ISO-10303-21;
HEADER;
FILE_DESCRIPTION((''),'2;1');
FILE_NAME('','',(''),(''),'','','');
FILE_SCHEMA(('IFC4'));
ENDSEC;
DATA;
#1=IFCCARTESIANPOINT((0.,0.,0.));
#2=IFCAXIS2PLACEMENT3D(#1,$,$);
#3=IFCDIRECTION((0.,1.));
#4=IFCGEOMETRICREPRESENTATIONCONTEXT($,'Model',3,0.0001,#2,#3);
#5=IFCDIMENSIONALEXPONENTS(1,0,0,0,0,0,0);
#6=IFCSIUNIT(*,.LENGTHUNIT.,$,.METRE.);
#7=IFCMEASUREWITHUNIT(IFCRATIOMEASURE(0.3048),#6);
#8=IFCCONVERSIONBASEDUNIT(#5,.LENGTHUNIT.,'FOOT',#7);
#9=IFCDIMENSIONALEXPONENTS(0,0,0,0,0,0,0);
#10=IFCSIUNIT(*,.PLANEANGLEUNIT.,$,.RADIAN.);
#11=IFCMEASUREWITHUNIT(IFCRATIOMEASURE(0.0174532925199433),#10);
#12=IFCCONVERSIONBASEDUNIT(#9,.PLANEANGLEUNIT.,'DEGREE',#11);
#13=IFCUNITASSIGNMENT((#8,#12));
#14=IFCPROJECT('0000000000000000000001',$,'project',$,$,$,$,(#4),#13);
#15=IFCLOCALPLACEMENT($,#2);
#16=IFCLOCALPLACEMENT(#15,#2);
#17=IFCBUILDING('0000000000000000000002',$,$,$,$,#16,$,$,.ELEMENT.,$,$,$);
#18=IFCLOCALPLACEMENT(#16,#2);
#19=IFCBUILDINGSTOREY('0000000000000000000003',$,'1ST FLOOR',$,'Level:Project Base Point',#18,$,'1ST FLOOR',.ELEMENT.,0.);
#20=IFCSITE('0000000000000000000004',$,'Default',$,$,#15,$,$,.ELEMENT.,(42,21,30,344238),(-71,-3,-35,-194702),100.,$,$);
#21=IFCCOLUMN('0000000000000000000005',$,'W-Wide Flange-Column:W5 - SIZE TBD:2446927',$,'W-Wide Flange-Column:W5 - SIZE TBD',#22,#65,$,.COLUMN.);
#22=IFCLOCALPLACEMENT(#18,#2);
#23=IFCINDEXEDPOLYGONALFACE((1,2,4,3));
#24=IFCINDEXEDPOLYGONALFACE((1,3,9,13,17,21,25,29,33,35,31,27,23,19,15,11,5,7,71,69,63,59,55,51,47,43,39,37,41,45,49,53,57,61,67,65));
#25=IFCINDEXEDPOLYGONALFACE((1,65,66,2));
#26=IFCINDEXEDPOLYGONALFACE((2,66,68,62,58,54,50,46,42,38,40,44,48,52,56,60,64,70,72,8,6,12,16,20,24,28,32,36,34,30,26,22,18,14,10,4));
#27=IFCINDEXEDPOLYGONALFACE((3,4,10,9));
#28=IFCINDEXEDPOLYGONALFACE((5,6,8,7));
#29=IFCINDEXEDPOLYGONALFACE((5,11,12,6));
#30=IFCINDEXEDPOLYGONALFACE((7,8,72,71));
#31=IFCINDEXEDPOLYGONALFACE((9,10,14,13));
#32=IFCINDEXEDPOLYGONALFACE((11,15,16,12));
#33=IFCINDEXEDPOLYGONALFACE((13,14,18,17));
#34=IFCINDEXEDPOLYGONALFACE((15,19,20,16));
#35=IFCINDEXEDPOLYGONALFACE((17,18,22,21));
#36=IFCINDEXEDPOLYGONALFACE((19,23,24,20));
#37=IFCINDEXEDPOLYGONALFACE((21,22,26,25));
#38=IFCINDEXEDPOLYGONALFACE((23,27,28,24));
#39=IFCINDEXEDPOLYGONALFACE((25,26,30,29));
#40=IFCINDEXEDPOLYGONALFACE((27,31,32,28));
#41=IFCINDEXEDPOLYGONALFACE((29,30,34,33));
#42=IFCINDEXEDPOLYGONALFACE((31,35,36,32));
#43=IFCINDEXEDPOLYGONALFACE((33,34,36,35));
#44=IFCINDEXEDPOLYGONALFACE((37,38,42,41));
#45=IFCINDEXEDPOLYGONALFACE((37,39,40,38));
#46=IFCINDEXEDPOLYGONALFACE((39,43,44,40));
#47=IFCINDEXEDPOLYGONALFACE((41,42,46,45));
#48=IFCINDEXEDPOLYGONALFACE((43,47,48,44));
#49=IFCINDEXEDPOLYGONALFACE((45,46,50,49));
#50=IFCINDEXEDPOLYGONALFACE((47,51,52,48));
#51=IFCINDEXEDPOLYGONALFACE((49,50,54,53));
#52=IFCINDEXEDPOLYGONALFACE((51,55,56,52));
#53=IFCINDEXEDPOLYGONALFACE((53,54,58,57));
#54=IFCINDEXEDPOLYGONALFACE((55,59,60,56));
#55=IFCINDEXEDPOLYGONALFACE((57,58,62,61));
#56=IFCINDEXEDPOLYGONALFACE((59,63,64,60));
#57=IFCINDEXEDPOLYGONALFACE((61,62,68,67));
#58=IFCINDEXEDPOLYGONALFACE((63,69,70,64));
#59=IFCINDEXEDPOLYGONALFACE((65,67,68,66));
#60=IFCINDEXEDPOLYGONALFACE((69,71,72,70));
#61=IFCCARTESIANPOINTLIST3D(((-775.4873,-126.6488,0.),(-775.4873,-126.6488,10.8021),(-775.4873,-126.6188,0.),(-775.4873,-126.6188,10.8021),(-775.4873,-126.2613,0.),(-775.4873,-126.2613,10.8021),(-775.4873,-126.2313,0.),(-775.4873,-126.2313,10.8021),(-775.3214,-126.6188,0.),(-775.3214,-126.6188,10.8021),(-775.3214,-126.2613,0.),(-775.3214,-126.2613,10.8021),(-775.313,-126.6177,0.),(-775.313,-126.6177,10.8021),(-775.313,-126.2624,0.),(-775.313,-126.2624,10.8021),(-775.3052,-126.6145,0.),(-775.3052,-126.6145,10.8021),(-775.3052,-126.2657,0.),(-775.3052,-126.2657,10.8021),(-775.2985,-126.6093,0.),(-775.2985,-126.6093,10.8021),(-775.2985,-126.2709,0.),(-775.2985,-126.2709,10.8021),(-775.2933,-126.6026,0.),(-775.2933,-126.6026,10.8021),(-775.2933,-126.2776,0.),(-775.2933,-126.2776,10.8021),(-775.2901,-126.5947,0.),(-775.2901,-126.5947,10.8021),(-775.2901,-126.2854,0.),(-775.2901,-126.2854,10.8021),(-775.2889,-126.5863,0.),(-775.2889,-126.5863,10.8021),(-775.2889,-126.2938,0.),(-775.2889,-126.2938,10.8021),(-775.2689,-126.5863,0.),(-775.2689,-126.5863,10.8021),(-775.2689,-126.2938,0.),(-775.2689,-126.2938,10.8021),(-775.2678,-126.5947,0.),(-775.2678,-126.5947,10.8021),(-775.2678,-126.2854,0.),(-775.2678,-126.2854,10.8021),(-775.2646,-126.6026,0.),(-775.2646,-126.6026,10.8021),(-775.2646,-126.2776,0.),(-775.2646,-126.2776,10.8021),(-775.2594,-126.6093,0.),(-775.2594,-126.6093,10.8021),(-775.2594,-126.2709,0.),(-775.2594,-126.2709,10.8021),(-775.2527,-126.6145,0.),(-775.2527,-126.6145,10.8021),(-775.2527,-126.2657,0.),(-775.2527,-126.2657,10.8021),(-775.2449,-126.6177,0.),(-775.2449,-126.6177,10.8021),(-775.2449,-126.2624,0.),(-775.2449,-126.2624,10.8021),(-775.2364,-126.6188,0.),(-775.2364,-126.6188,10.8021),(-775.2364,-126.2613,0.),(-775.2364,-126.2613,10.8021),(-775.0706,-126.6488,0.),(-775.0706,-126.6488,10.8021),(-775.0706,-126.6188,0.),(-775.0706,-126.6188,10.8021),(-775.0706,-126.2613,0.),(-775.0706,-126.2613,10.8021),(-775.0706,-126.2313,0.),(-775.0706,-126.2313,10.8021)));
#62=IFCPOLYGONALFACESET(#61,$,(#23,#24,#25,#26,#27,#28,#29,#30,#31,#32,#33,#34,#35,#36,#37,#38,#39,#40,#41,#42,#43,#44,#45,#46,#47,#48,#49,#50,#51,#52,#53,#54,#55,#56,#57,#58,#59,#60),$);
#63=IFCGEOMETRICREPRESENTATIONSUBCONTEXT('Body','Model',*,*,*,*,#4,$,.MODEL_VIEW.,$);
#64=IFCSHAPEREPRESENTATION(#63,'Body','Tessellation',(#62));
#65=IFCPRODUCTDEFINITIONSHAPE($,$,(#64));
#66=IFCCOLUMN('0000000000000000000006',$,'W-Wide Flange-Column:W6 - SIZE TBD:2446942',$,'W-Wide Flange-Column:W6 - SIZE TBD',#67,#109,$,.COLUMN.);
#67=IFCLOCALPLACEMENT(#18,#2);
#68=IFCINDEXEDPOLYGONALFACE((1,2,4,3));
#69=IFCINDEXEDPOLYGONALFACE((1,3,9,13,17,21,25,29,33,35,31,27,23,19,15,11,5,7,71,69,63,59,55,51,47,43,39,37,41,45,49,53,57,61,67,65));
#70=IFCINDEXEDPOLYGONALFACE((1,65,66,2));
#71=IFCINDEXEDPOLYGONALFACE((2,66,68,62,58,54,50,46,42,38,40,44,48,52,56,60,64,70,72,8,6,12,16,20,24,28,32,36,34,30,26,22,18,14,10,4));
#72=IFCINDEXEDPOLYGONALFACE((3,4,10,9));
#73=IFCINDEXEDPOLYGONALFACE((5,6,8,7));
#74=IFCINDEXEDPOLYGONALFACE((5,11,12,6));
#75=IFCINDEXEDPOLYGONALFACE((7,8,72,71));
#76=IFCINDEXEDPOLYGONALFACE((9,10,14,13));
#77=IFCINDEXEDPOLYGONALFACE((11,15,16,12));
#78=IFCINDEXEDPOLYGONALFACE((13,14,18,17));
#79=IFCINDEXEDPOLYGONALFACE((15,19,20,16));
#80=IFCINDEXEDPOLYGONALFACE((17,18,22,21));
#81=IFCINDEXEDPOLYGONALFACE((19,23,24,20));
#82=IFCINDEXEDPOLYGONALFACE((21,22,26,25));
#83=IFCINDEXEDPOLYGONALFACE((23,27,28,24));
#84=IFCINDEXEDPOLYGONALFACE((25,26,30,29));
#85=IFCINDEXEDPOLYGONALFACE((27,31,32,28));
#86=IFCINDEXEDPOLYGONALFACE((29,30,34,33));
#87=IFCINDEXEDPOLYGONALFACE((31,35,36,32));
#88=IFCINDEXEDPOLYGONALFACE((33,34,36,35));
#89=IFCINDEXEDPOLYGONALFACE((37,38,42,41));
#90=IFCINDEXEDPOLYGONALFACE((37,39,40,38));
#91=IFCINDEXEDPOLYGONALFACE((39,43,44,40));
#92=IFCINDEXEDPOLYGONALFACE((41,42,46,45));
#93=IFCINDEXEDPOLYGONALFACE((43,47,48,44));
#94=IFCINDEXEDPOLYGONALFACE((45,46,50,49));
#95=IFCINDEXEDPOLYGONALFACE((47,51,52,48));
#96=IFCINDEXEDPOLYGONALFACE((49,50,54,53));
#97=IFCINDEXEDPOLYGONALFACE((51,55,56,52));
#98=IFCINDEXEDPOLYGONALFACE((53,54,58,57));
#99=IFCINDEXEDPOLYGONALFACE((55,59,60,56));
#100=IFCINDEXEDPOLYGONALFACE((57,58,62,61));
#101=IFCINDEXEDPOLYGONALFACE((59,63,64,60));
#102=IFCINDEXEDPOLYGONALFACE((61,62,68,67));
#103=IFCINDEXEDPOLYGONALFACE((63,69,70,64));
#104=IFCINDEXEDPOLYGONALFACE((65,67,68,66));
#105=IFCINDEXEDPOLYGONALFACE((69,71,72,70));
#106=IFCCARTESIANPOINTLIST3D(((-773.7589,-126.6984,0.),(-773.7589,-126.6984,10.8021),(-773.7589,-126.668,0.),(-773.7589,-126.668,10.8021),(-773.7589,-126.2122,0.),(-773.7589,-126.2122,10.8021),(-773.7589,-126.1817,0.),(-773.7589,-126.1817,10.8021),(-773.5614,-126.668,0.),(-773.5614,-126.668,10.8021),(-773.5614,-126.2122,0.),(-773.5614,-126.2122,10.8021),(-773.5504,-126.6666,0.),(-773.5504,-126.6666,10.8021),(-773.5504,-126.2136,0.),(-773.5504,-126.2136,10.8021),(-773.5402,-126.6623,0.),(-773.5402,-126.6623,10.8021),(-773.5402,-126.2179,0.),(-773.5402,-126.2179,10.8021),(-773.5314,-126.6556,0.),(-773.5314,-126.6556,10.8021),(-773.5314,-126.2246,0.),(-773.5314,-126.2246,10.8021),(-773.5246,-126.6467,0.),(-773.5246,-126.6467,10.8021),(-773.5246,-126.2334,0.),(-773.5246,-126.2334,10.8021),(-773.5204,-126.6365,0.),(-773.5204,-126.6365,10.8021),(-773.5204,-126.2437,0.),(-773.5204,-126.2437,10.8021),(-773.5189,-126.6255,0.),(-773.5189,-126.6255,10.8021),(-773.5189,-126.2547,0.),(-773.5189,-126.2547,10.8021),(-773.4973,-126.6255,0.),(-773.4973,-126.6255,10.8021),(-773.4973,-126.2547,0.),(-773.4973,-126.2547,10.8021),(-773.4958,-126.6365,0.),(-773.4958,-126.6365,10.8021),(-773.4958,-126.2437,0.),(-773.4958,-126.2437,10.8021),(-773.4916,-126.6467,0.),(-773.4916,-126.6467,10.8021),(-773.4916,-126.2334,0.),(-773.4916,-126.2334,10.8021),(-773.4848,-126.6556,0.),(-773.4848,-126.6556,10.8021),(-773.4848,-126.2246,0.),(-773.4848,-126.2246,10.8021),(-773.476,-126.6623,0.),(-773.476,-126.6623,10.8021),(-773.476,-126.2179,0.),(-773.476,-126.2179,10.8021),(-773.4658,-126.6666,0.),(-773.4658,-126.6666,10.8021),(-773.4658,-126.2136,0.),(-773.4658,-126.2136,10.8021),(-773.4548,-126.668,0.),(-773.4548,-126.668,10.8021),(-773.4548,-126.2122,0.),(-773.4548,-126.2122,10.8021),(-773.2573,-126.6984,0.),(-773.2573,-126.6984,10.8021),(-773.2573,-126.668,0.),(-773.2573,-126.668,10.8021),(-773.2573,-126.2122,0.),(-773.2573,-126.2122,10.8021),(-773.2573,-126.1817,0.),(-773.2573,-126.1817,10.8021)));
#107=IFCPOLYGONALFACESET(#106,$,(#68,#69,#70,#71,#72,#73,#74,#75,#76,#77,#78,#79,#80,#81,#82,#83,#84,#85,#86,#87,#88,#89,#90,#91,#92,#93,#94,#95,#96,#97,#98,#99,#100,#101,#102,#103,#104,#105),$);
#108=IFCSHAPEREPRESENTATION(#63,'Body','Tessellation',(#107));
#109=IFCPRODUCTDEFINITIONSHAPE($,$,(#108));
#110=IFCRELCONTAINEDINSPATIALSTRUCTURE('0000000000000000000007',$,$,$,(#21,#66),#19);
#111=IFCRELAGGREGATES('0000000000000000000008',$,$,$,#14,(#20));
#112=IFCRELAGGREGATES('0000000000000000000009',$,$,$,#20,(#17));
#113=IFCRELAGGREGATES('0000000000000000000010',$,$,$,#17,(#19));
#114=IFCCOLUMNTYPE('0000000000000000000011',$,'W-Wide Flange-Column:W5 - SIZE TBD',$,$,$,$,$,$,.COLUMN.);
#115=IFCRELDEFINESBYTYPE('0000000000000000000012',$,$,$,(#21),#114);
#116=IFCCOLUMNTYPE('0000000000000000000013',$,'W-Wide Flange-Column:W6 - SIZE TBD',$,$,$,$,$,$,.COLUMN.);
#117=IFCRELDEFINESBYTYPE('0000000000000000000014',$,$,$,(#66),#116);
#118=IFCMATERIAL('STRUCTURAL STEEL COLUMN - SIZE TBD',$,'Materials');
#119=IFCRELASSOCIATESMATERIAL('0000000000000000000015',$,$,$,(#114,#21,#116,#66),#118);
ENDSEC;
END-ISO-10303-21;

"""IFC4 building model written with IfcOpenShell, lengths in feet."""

from ifc_helpers import new_model, entity, si_unit, converted_unit, direction, frame, frame_2d, origin, place, context, subcontext, project, spatial, polyline, circle_curve, parameter, trimmed, segment, composite_curve, outline, extrude, source, transform, mapped, material, material_profile, profile_set, profile_usage, type_object, type_shapes, element, save


model = new_model("IFC4")

# Units and contexts
model_context = context("Model", 3, precision=0.0001, world=origin(), true_north=direction((0.0, 1.0)))
body_context = subcontext(model_context, "Body", "Model", "MODEL_VIEW")
ifc_project = project(units=[converted_unit("LENGTHUNIT", "FOOT", entity("IfcRatioMeasure", 0.3048), si_unit("LENGTHUNIT", "METRE"), dimensions=[1, 0, 0, 0, 0, 0, 0]), converted_unit("PLANEANGLEUNIT", "DEGREE", entity("IfcRatioMeasure", 0.0174532925199433), si_unit("PLANEANGLEUNIT", "RADIAN"), dimensions=[0, 0, 0, 0, 0, 0, 0])], contexts=[model_context])

# Site, building, storey
site_placement = place(None, origin())
site = spatial("IfcSite", under=ifc_project, at=site_placement, Name="Default", CompositionType="ELEMENT", RefLatitude=(42, 21, 30, 344238), RefLongitude=(-71, -3, -35, -194702), RefElevation=100.0)
building_placement = place(site_placement, origin())
building = spatial("IfcBuilding", under=site, at=building_placement, CompositionType="ELEMENT")
storey_placement = place(building_placement, origin())
storey = spatial("IfcBuildingStorey", under=building, at=storey_placement, Name="1ST FLOOR", ObjectType="Level:Project Base Point", LongName="1ST FLOOR", CompositionType="ELEMENT", Elevation=0.0)

# Columns
ifc_material_1 = material(Name="STRUCTURAL STEEL COLUMN - SIZE TBD", Category="Materials")
ifc_material_profile_1 = material_profile(ifc_material_1, outline(composite_curve([segment(polyline([(0.1787, -0.2083), (0.2087, -0.2083)]), True, "CONTINUOUS"), segment(polyline([(0.2087, -0.2083), (0.2087, 0.2083)]), True, "CONTINUOUS"), segment(polyline([(0.2087, 0.2083), (0.1787, 0.2083)]), True, "CONTINUOUS"), segment(polyline([(0.1787, 0.2083), (0.1787, 0.0425)]), True, "CONTINUOUS"), segment(trimmed(circle_curve(frame_2d((0.1462, 0.0425), x_axis=(1.0, 0.0)), 0.0325), [parameter(270.0)], [parameter(0.0)], True, "PARAMETER"), False, "CONTINUOUS"), segment(polyline([(0.1462, 0.01), (-0.1462, 0.01)]), True, "CONTINUOUS"), segment(trimmed(circle_curve(frame_2d((-0.1462, 0.0425), x_axis=(0.0, -1.0)), 0.0325), [parameter(270.0)], [parameter(0.0)], True, "PARAMETER"), False, "CONTINUOUS"), segment(polyline([(-0.1787, 0.0425), (-0.1787, 0.2083)]), True, "CONTINUOUS"), segment(polyline([(-0.1787, 0.2083), (-0.2087, 0.2083)]), True, "CONTINUOUS"), segment(polyline([(-0.2087, 0.2083), (-0.2087, -0.2083)]), True, "CONTINUOUS"), segment(polyline([(-0.2087, -0.2083), (-0.1787, -0.2083)]), True, "CONTINUOUS"), segment(polyline([(-0.1787, -0.2083), (-0.1787, -0.0425)]), True, "CONTINUOUS"), segment(trimmed(circle_curve(frame_2d((-0.1462, -0.0425), x_axis=(-1.0, 0.0)), 0.0325), [parameter(270.0)], [parameter(0.0)], True, "PARAMETER"), False, "CONTINUOUS"), segment(polyline([(-0.1462, -0.01), (0.1462, -0.01)]), True, "CONTINUOUS"), segment(trimmed(circle_curve(frame_2d((0.1462, -0.0425), x_axis=(0.0, 1.0)), 0.0325), [parameter(270.0)], [parameter(0.0)], True, "PARAMETER"), False, "CONTINUOUS"), segment(polyline([(0.1787, -0.0425), (0.1787, -0.2083)]), True, "CONTINUOUS")], self_intersect=False)), Name="W5 - SIZE TBD")
ifc_profile_set_1 = profile_set([ifc_material_profile_1], Name="W5 - SIZE TBD")
ifc_profile_usage_1 = profile_usage(ifc_profile_set_1)
column_type_1 = type_object("IfcColumnType", Name="W-Wide Flange-Column:W5 - SIZE TBD", PredefinedType="COLUMN", material=ifc_profile_set_1)
shared_shape_1 = source(origin(), body_context, "Body", "SweptSolid", [
    extrude(outline(composite_curve([segment(polyline([(0.1787, -0.2083), (0.2087, -0.2083)]), True, "CONTINUOUS"), segment(polyline([(0.2087, -0.2083), (0.2087, 0.2083)]), True, "CONTINUOUS"), segment(polyline([(0.2087, 0.2083), (0.1787, 0.2083)]), True, "CONTINUOUS"), segment(polyline([(0.1787, 0.2083), (0.1787, 0.0425)]), True, "CONTINUOUS"), segment(trimmed(circle_curve(frame_2d((0.1462, 0.0425), x_axis=(1.0, 0.0)), 0.0325), [parameter(270.0)], [parameter(0.0)], True, "PARAMETER"), False, "CONTINUOUS"), segment(polyline([(0.1462, 0.01), (-0.1462, 0.01)]), True, "CONTINUOUS"), segment(trimmed(circle_curve(frame_2d((-0.1462, 0.0425), x_axis=(0.0, -1.0)), 0.0325), [parameter(270.0)], [parameter(0.0)], True, "PARAMETER"), False, "CONTINUOUS"), segment(polyline([(-0.1787, 0.0425), (-0.1787, 0.2083)]), True, "CONTINUOUS"), segment(polyline([(-0.1787, 0.2083), (-0.2087, 0.2083)]), True, "CONTINUOUS"), segment(polyline([(-0.2087, 0.2083), (-0.2087, -0.2083)]), True, "CONTINUOUS"), segment(polyline([(-0.2087, -0.2083), (-0.1787, -0.2083)]), True, "CONTINUOUS"), segment(polyline([(-0.1787, -0.2083), (-0.1787, -0.0425)]), True, "CONTINUOUS"), segment(trimmed(circle_curve(frame_2d((-0.1462, -0.0425), x_axis=(-1.0, 0.0)), 0.0325), [parameter(270.0)], [parameter(0.0)], True, "PARAMETER"), False, "CONTINUOUS"), segment(polyline([(-0.1462, -0.01), (0.1462, -0.01)]), True, "CONTINUOUS"), segment(trimmed(circle_curve(frame_2d((0.1462, -0.0425), x_axis=(0.0, 1.0)), 0.0325), [parameter(270.0)], [parameter(0.0)], True, "PARAMETER"), False, "CONTINUOUS"), segment(polyline([(0.1787, -0.0425), (0.1787, -0.2083)]), True, "CONTINUOUS")], self_intersect=False)), frame((0.0, 0.0, 0.0), z_axis=(0.0, 0.0, 1.0), x_axis=(0.0, -1.0, 0.0)), (0.0, 0.0, 1.0), 10.8021),
])
type_shapes(column_type_1, [shared_shape_1])
column_1_placement = place(storey_placement, frame((-775.2789, -126.4401, 0.0)))
element("IfcColumn", 1, at=column_1_placement, inside=storey, type_object=column_type_1, material=ifc_profile_usage_1, Name="W-Wide Flange-Column:W5 - SIZE TBD:2446927", ObjectType="W-Wide Flange-Column:W5 - SIZE TBD", PredefinedType="COLUMN", context=body_context, shape_type="MappedRepresentation", body=[
    mapped(shared_shape_1, transform((0.0, 0.0, 0.0), scale=1.0)),
])
ifc_material_profile_2 = material_profile(ifc_material_1, outline(composite_curve([segment(polyline([(0.2279, -0.2508), (0.2583, -0.2508)]), True, "CONTINUOUS"), segment(polyline([(0.2583, -0.2508), (0.2583, 0.2508)]), True, "CONTINUOUS"), segment(polyline([(0.2583, 0.2508), (0.2279, 0.2508)]), True, "CONTINUOUS"), segment(polyline([(0.2279, 0.2508), (0.2279, 0.0533)]), True, "CONTINUOUS"), segment(trimmed(circle_curve(frame_2d((0.1854, 0.0533), x_axis=(1.0, 0.0)), 0.0425), [parameter(270.0)], [parameter(0.0)], True, "PARAMETER"), False, "CONTINUOUS"), segment(polyline([(0.1854, 0.0108), (-0.1854, 0.0108)]), True, "CONTINUOUS"), segment(trimmed(circle_curve(frame_2d((-0.1854, 0.0533), x_axis=(0.0, -1.0)), 0.0425), [parameter(270.0)], [parameter(0.0)], True, "PARAMETER"), False, "CONTINUOUS"), segment(polyline([(-0.2279, 0.0533), (-0.2279, 0.2508)]), True, "CONTINUOUS"), segment(polyline([(-0.2279, 0.2508), (-0.2583, 0.2508)]), True, "CONTINUOUS"), segment(polyline([(-0.2583, 0.2508), (-0.2583, -0.2508)]), True, "CONTINUOUS"), segment(polyline([(-0.2583, -0.2508), (-0.2279, -0.2508)]), True, "CONTINUOUS"), segment(polyline([(-0.2279, -0.2508), (-0.2279, -0.0533)]), True, "CONTINUOUS"), segment(trimmed(circle_curve(frame_2d((-0.1854, -0.0533), x_axis=(-1.0, 0.0)), 0.0425), [parameter(270.0)], [parameter(0.0)], True, "PARAMETER"), False, "CONTINUOUS"), segment(polyline([(-0.1854, -0.0108), (0.1854, -0.0108)]), True, "CONTINUOUS"), segment(trimmed(circle_curve(frame_2d((0.1854, -0.0533), x_axis=(0.0, 1.0)), 0.0425), [parameter(270.0)], [parameter(0.0)], True, "PARAMETER"), False, "CONTINUOUS"), segment(polyline([(0.2279, -0.0533), (0.2279, -0.2508)]), True, "CONTINUOUS")], self_intersect=False)), Name="W6 - SIZE TBD")
ifc_profile_set_2 = profile_set([ifc_material_profile_2], Name="W6 - SIZE TBD")
ifc_profile_usage_2 = profile_usage(ifc_profile_set_2)
column_type_2 = type_object("IfcColumnType", Name="W-Wide Flange-Column:W6 - SIZE TBD", PredefinedType="COLUMN", material=ifc_profile_set_2)
shared_shape_2 = source(origin(), body_context, "Body", "SweptSolid", [
    extrude(outline(composite_curve([segment(polyline([(0.2279, -0.2508), (0.2583, -0.2508)]), True, "CONTINUOUS"), segment(polyline([(0.2583, -0.2508), (0.2583, 0.2508)]), True, "CONTINUOUS"), segment(polyline([(0.2583, 0.2508), (0.2279, 0.2508)]), True, "CONTINUOUS"), segment(polyline([(0.2279, 0.2508), (0.2279, 0.0533)]), True, "CONTINUOUS"), segment(trimmed(circle_curve(frame_2d((0.1854, 0.0533), x_axis=(1.0, 0.0)), 0.0425), [parameter(270.0)], [parameter(0.0)], True, "PARAMETER"), False, "CONTINUOUS"), segment(polyline([(0.1854, 0.0108), (-0.1854, 0.0108)]), True, "CONTINUOUS"), segment(trimmed(circle_curve(frame_2d((-0.1854, 0.0533), x_axis=(0.0, -1.0)), 0.0425), [parameter(270.0)], [parameter(0.0)], True, "PARAMETER"), False, "CONTINUOUS"), segment(polyline([(-0.2279, 0.0533), (-0.2279, 0.2508)]), True, "CONTINUOUS"), segment(polyline([(-0.2279, 0.2508), (-0.2583, 0.2508)]), True, "CONTINUOUS"), segment(polyline([(-0.2583, 0.2508), (-0.2583, -0.2508)]), True, "CONTINUOUS"), segment(polyline([(-0.2583, -0.2508), (-0.2279, -0.2508)]), True, "CONTINUOUS"), segment(polyline([(-0.2279, -0.2508), (-0.2279, -0.0533)]), True, "CONTINUOUS"), segment(trimmed(circle_curve(frame_2d((-0.1854, -0.0533), x_axis=(-1.0, 0.0)), 0.0425), [parameter(270.0)], [parameter(0.0)], True, "PARAMETER"), False, "CONTINUOUS"), segment(polyline([(-0.1854, -0.0108), (0.1854, -0.0108)]), True, "CONTINUOUS"), segment(trimmed(circle_curve(frame_2d((0.1854, -0.0533), x_axis=(0.0, 1.0)), 0.0425), [parameter(270.0)], [parameter(0.0)], True, "PARAMETER"), False, "CONTINUOUS"), segment(polyline([(0.2279, -0.0533), (0.2279, -0.2508)]), True, "CONTINUOUS")], self_intersect=False)), frame((0.0, 0.0, 0.0), z_axis=(0.0, 0.0, 1.0), x_axis=(0.0, -1.0, 0.0)), (0.0, 0.0, 1.0), 10.8021),
])
type_shapes(column_type_2, [shared_shape_2])
column_2_placement = place(storey_placement, frame((-773.5081, -126.4401, 0.0)))
element("IfcColumn", 2, at=column_2_placement, inside=storey, type_object=column_type_2, material=ifc_profile_usage_2, Name="W-Wide Flange-Column:W6 - SIZE TBD:2446942", ObjectType="W-Wide Flange-Column:W6 - SIZE TBD", PredefinedType="COLUMN", context=body_context, shape_type="MappedRepresentation", body=[
    mapped(shared_shape_2, transform((0.0, 0.0, 0.0), scale=1.0)),
])

save(model, "model.ifc")
